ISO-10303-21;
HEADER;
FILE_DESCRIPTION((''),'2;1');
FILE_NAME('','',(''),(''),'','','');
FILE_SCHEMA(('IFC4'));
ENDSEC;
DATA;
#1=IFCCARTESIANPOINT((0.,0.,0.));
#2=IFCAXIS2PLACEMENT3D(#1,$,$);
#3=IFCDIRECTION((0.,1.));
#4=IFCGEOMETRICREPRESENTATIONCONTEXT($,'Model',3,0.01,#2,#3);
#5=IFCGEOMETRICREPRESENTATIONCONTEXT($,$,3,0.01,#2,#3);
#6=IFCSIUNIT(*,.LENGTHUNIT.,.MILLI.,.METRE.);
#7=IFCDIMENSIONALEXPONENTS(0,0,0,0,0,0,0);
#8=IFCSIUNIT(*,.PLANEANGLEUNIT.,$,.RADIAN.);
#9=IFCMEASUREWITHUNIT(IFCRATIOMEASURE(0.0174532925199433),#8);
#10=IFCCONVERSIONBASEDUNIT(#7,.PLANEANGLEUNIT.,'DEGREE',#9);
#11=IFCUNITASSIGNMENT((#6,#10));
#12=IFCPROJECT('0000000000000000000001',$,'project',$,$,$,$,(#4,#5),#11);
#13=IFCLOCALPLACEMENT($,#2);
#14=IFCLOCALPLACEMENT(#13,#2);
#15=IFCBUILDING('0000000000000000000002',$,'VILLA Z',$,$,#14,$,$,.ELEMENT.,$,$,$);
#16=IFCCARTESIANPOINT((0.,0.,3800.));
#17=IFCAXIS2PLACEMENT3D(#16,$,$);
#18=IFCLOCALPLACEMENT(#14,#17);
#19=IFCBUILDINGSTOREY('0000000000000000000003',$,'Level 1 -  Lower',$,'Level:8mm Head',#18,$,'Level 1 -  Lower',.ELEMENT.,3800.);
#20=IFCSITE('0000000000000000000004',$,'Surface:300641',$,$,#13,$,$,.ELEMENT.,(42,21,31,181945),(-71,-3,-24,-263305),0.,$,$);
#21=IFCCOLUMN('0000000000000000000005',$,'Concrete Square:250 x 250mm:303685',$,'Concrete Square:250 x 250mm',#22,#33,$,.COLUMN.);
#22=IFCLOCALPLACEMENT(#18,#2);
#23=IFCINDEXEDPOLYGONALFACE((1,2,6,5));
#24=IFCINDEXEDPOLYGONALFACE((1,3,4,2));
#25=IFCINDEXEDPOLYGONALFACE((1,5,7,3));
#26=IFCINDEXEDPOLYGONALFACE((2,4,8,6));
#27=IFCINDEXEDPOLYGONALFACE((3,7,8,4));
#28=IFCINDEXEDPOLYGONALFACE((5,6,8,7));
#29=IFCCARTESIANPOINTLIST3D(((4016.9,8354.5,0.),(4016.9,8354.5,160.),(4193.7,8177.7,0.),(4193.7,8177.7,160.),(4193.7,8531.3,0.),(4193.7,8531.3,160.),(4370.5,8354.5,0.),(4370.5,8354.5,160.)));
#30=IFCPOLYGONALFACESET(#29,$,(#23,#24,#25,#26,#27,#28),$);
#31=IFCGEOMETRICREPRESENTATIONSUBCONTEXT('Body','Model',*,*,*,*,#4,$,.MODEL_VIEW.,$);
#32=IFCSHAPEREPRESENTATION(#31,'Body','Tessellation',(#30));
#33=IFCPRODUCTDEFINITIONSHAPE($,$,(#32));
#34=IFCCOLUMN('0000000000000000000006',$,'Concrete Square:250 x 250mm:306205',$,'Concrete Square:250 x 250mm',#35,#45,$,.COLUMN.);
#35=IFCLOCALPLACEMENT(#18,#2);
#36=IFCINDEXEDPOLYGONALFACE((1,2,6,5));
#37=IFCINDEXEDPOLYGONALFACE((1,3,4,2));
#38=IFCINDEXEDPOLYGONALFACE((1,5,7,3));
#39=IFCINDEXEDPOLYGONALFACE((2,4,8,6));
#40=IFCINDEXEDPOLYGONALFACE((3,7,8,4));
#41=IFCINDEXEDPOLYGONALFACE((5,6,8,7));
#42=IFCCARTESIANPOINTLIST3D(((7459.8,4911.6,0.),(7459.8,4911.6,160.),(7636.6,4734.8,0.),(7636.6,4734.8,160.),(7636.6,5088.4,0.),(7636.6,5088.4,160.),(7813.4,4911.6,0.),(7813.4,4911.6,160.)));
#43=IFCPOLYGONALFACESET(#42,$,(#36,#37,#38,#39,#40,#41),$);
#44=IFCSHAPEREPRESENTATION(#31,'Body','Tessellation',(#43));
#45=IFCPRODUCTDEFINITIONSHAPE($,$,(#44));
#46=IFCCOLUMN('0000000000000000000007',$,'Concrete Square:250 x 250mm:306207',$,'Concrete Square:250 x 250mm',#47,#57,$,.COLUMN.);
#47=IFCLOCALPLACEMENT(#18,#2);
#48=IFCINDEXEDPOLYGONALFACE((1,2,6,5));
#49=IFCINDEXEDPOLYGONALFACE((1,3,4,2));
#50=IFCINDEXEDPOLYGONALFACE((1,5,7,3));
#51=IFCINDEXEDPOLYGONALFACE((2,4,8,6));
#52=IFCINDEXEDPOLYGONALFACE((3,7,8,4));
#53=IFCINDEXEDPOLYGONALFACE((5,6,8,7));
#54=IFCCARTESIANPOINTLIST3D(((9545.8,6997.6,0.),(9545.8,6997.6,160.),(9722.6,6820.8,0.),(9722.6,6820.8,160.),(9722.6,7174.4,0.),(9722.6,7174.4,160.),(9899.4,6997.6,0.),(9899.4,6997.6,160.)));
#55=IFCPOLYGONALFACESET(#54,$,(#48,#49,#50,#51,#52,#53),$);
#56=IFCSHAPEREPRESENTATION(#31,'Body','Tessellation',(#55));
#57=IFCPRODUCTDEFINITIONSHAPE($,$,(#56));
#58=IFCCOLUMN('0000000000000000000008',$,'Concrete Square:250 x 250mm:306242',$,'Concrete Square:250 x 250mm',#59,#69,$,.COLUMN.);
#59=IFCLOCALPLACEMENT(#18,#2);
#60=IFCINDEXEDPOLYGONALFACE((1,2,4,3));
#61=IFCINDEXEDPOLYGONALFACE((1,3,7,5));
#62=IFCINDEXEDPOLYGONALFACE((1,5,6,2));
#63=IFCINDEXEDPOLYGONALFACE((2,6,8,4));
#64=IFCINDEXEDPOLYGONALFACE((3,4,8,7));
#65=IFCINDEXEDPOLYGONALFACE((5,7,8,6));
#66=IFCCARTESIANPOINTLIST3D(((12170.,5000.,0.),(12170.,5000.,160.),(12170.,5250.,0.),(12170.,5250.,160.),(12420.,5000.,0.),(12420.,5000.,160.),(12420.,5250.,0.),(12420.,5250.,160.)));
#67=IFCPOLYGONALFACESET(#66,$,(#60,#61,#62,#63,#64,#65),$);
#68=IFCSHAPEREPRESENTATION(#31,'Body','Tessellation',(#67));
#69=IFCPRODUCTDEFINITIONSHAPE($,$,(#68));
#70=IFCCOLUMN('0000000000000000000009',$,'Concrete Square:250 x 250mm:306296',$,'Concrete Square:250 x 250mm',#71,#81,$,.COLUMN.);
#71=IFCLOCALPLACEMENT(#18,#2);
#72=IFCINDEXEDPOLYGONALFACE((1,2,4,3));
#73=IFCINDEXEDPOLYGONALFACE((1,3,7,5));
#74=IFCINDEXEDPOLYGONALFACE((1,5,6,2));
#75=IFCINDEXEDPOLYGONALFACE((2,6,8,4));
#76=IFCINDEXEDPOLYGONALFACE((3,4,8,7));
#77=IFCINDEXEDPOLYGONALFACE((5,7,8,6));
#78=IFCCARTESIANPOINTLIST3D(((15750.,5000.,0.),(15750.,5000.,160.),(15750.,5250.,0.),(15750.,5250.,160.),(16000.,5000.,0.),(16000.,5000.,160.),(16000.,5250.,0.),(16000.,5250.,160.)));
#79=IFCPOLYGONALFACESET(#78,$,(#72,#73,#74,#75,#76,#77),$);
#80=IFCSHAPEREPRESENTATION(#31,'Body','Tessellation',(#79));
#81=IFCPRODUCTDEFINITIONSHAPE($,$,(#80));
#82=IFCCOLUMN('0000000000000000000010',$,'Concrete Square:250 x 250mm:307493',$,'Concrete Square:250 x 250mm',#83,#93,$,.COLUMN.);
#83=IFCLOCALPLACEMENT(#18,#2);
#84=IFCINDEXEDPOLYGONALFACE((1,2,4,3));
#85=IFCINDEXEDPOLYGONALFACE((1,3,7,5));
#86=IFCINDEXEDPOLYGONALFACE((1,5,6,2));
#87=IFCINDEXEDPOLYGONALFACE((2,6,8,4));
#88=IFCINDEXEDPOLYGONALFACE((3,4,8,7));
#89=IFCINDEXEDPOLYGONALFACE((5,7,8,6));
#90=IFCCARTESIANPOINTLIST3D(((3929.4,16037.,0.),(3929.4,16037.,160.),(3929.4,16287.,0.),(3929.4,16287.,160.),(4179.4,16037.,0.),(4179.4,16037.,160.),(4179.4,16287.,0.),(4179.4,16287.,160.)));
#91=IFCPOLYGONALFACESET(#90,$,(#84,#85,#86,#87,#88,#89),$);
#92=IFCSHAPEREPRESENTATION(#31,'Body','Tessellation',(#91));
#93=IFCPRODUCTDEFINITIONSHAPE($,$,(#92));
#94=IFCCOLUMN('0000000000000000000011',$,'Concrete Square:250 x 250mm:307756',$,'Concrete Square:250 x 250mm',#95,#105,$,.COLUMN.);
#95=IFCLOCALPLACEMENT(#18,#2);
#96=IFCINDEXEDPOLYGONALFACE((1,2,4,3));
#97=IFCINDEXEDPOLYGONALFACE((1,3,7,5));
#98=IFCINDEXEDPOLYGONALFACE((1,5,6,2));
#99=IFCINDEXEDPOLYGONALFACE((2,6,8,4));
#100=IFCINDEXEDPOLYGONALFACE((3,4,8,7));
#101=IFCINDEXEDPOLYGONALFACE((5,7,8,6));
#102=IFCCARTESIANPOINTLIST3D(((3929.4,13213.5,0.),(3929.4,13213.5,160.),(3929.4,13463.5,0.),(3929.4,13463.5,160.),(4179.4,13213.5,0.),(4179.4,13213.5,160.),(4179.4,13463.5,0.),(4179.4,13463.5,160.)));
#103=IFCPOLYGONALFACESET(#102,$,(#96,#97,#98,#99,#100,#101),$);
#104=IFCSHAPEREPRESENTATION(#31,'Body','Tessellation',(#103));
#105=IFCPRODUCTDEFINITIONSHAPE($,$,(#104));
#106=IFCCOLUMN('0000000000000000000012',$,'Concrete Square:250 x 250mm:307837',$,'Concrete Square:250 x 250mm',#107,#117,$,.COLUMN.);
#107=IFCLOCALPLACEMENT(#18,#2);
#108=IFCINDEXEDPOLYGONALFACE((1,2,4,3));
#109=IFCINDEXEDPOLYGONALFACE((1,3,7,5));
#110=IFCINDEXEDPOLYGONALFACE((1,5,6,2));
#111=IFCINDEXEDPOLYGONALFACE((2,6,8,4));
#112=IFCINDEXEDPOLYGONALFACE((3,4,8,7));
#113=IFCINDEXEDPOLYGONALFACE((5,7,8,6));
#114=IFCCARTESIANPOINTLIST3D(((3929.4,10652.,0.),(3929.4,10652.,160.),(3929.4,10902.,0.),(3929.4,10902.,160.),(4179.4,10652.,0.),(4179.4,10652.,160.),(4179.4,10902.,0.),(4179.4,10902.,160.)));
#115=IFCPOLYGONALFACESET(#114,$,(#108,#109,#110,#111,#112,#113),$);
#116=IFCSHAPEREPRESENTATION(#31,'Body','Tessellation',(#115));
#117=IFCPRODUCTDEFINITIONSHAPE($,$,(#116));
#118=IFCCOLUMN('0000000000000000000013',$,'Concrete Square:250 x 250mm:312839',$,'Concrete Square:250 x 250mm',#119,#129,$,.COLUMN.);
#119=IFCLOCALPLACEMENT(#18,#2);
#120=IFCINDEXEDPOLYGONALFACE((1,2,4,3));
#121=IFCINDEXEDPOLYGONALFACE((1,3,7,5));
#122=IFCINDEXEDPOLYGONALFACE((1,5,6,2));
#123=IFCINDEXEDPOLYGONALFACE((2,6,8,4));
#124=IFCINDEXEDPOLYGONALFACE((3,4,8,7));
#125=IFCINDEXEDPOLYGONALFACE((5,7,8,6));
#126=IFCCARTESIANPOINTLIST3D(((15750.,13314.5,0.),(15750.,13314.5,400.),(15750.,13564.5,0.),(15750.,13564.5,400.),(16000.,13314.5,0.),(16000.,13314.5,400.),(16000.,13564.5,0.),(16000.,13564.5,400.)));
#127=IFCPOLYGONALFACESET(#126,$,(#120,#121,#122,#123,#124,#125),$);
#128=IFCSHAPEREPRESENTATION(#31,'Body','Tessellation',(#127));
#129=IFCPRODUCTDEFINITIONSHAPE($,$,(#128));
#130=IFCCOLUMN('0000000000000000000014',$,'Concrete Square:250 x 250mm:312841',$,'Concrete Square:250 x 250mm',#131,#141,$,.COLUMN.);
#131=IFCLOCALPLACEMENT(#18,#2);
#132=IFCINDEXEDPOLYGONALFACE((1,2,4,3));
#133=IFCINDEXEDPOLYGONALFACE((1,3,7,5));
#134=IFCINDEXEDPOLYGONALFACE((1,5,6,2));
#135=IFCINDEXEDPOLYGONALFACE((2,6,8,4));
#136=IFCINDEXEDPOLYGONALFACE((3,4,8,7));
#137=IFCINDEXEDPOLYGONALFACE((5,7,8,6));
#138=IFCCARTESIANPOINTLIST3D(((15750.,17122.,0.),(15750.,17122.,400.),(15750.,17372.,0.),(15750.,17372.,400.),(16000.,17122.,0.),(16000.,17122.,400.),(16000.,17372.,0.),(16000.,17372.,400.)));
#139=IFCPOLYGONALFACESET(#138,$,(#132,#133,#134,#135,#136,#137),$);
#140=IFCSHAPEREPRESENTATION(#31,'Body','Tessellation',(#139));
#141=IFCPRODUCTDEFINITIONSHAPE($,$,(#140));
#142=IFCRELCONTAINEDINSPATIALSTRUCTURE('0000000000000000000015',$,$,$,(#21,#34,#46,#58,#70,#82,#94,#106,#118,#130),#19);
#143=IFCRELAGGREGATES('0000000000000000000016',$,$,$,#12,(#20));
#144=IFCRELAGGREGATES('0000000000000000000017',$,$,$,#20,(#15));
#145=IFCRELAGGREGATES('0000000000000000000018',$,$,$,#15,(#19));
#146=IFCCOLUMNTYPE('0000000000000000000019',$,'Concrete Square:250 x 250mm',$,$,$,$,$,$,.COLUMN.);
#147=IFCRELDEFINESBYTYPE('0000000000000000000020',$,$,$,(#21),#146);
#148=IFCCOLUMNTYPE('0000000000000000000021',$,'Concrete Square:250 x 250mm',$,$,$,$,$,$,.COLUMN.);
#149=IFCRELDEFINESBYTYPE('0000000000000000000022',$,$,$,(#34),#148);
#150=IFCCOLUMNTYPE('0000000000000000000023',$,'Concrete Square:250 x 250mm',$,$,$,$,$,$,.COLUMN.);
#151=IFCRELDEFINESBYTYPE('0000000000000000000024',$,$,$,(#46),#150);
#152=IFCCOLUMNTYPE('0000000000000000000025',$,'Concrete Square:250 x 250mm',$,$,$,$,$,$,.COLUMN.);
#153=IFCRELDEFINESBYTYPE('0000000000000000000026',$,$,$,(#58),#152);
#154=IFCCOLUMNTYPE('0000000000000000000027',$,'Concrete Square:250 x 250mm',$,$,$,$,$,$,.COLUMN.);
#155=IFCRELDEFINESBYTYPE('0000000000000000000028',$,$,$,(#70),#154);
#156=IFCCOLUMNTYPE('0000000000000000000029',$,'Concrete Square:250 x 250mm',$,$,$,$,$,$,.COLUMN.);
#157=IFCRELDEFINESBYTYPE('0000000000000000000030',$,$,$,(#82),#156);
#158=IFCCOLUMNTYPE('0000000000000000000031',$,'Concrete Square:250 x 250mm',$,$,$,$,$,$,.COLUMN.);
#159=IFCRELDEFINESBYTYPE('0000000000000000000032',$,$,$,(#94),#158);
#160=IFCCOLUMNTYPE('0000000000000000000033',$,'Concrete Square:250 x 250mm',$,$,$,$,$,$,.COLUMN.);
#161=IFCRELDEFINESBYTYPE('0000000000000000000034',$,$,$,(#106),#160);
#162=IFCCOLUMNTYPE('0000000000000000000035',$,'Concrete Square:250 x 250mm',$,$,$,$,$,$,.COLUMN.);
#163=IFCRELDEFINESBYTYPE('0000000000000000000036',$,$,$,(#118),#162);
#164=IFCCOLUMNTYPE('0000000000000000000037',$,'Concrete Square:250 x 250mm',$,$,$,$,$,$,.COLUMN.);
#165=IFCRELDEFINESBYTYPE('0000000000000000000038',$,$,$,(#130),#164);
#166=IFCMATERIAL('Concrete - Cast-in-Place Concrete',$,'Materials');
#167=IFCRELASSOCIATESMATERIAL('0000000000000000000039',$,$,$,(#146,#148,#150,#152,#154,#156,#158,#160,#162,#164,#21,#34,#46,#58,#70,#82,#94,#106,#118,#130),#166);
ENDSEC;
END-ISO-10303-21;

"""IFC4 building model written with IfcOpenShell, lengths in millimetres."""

from ifc_helpers import new_model, entity, si_unit, converted_unit, direction, frame, frame_2d, origin, origin_2d_with_axis, place, context, subcontext, project, spatial, rectangle, extrude, source, transform, mapped, material, material_profile, profile_set, profile_usage, type_object, type_shapes, element, save


model = new_model("IFC4")

# Units and contexts
model_context = context("Model", 3, precision=0.01, world=origin(), true_north=direction((0.0, 1.0)))
context_of_model = context(None, 3, precision=0.01, world=origin(), true_north=direction((0.0, 1.0)))
body_context = subcontext(model_context, "Body", "Model", "MODEL_VIEW")
ifc_project = project(units=[si_unit("LENGTHUNIT", "METRE", prefix="MILLI"), converted_unit("PLANEANGLEUNIT", "DEGREE", entity("IfcRatioMeasure", 0.0174532925199433), si_unit("PLANEANGLEUNIT", "RADIAN"), dimensions=[0, 0, 0, 0, 0, 0, 0])], contexts=[model_context, context_of_model])

# Site, building, storey
site_placement = place(None, origin())
site = spatial("IfcSite", under=ifc_project, at=site_placement, Name="Surface:300641", CompositionType="ELEMENT", RefLatitude=(42, 21, 31, 181945), RefLongitude=(-71, -3, -24, -263305), RefElevation=0.0)
building_placement = place(site_placement, origin())
building = spatial("IfcBuilding", under=site, at=building_placement, Name="VILLA Z", CompositionType="ELEMENT")
storey_placement = place(building_placement, frame((0.0, 0.0, 3800.0)))
storey = spatial("IfcBuildingStorey", under=building, at=storey_placement, Name="Level 1 -  Lower", ObjectType="Level:8mm Head", LongName="Level 1 -  Lower", CompositionType="ELEMENT", Elevation=3800.0)

# Columns
ifc_material_1 = material(Name="Concrete - Cast-in-Place Concrete", Category="Materials")
ifc_material_profile_1 = material_profile(ifc_material_1, rectangle(XDim=250.0, YDim=250.0, at=frame_2d((0.0, 0.0), x_axis=(1.0, 0.0))), Name="250 x 250mm")
ifc_profile_set_1 = profile_set([ifc_material_profile_1], Name="250 x 250mm")
ifc_profile_usage_1 = profile_usage(ifc_profile_set_1)
column_type_1 = type_object("IfcColumnType", Name="Concrete Square:250 x 250mm", PredefinedType="COLUMN", material=ifc_profile_set_1)
shared_shape_1 = source(origin(), body_context, "Body", "SweptSolid", [
    extrude(rectangle(XDim=250.0, YDim=250.0, at=frame_2d((0.0, 0.0), x_axis=(1.0, 0.0))), frame((4193.7, 8354.5, 3800.0), z_axis=(0.0, 0.0, 1.0), x_axis=(-0.707107, 0.707107, 0.0)), (0.0, 0.0, 1.0), 160.0),
])
type_shapes(column_type_1, [shared_shape_1])
column_1_placement = place(storey_placement, frame((0.0, 0.0, -3800.0)))
element("IfcColumn", 1, at=column_1_placement, inside=storey, type_object=column_type_1, material=ifc_profile_usage_1, Name="Concrete Square:250 x 250mm:303685", ObjectType="Concrete Square:250 x 250mm", PredefinedType="COLUMN", context=body_context, shape_type="MappedRepresentation", body=[
    mapped(shared_shape_1, transform((0.0, 0.0, 0.0), scale=1.0)),
])
ifc_profile_usage_2 = profile_usage(ifc_profile_set_1)
column_type_2 = type_object("IfcColumnType", Name="Concrete Square:250 x 250mm", PredefinedType="COLUMN", material=ifc_profile_set_1)
shared_shape_2 = source(origin(), body_context, "Body", "SweptSolid", [
    extrude(rectangle(XDim=250.0, YDim=250.0, at=frame_2d((0.0, 0.0), x_axis=(1.0, 0.0))), frame((7636.6, 4911.6, 3800.0), z_axis=(0.0, 0.0, 1.0), x_axis=(-0.707107, 0.707107, 0.0)), (0.0, 0.0, 1.0), 160.0),
])
type_shapes(column_type_2, [shared_shape_2])
column_2_placement = place(storey_placement, frame((0.0, 0.0, -3800.0)))
element("IfcColumn", 2, at=column_2_placement, inside=storey, type_object=column_type_2, material=ifc_profile_usage_2, Name="Concrete Square:250 x 250mm:306205", ObjectType="Concrete Square:250 x 250mm", PredefinedType="COLUMN", context=body_context, shape_type="MappedRepresentation", body=[
    mapped(shared_shape_2, transform((0.0, 0.0, 0.0), scale=1.0)),
])
ifc_profile_usage_3 = profile_usage(ifc_profile_set_1)
column_type_3 = type_object("IfcColumnType", Name="Concrete Square:250 x 250mm", PredefinedType="COLUMN", material=ifc_profile_set_1)
shared_shape_3 = source(origin(), body_context, "Body", "SweptSolid", [
    extrude(rectangle(XDim=250.0, YDim=250.0, at=frame_2d((0.0, 0.0), x_axis=(1.0, 0.0))), frame((9722.6, 6997.6, 3800.0), z_axis=(0.0, 0.0, 1.0), x_axis=(-0.707107, 0.707107, 0.0)), (0.0, 0.0, 1.0), 160.0),
])
type_shapes(column_type_3, [shared_shape_3])
column_3_placement = place(storey_placement, frame((0.0, 0.0, -3800.0)))
element("IfcColumn", 3, at=column_3_placement, inside=storey, type_object=column_type_3, material=ifc_profile_usage_3, Name="Concrete Square:250 x 250mm:306207", ObjectType="Concrete Square:250 x 250mm", PredefinedType="COLUMN", context=body_context, shape_type="MappedRepresentation", body=[
    mapped(shared_shape_3, transform((0.0, 0.0, 0.0), scale=1.0)),
])
ifc_profile_usage_4 = profile_usage(ifc_profile_set_1)
column_type_4 = type_object("IfcColumnType", Name="Concrete Square:250 x 250mm", PredefinedType="COLUMN", material=ifc_profile_set_1)
shared_shape_4 = source(origin(), body_context, "Body", "SweptSolid", [
    extrude(rectangle(XDim=250.0, YDim=250.0, at=origin_2d_with_axis()), frame((12295.0, 5125.0, 3800.0), z_axis=(0.0, 0.0, 1.0), x_axis=(0.0, -1.0, 0.0)), (0.0, 0.0, 1.0), 160.0),
])
type_shapes(column_type_4, [shared_shape_4])
column_4_placement = place(storey_placement, frame((0.0, 0.0, -3800.0)))
element("IfcColumn", 4, at=column_4_placement, inside=storey, type_object=column_type_4, material=ifc_profile_usage_4, Name="Concrete Square:250 x 250mm:306242", ObjectType="Concrete Square:250 x 250mm", PredefinedType="COLUMN", context=body_context, shape_type="MappedRepresentation", body=[
    mapped(shared_shape_4, transform((0.0, 0.0, 0.0), scale=1.0)),
])
ifc_profile_usage_5 = profile_usage(ifc_profile_set_1)
column_type_5 = type_object("IfcColumnType", Name="Concrete Square:250 x 250mm", PredefinedType="COLUMN", material=ifc_profile_set_1)
shared_shape_5 = source(origin(), body_context, "Body", "SweptSolid", [
    extrude(rectangle(XDim=250.0, YDim=250.0, at=origin_2d_with_axis()), frame((15875.0, 5125.0, 3800.0), z_axis=(0.0, 0.0, 1.0), x_axis=(0.0, -1.0, 0.0)), (0.0, 0.0, 1.0), 160.0),
])
type_shapes(column_type_5, [shared_shape_5])
column_5_placement = place(storey_placement, frame((0.0, 0.0, -3800.0)))
element("IfcColumn", 5, at=column_5_placement, inside=storey, type_object=column_type_5, material=ifc_profile_usage_5, Name="Concrete Square:250 x 250mm:306296", ObjectType="Concrete Square:250 x 250mm", PredefinedType="COLUMN", context=body_context, shape_type="MappedRepresentation", body=[
    mapped(shared_shape_5, transform((0.0, 0.0, 0.0), scale=1.0)),
])
ifc_profile_usage_6 = profile_usage(ifc_profile_set_1)
column_type_6 = type_object("IfcColumnType", Name="Concrete Square:250 x 250mm", PredefinedType="COLUMN", material=ifc_profile_set_1)
shared_shape_6 = source(origin(), body_context, "Body", "SweptSolid", [
    extrude(rectangle(XDim=250.0, YDim=250.0, at=frame_2d((0.0, 0.0), x_axis=(1.0, 0.0))), frame((4054.4, 16162.0, 3800.0), z_axis=(0.0, 0.0, 1.0), x_axis=(0.0, -1.0, 0.0)), (0.0, 0.0, 1.0), 160.0),
])
type_shapes(column_type_6, [shared_shape_6])
column_6_placement = place(storey_placement, frame((0.0, 0.0, -3800.0)))
element("IfcColumn", 6, at=column_6_placement, inside=storey, type_object=column_type_6, material=ifc_profile_usage_6, Name="Concrete Square:250 x 250mm:307493", ObjectType="Concrete Square:250 x 250mm", PredefinedType="COLUMN", context=body_context, shape_type="MappedRepresentation", body=[
    mapped(shared_shape_6, transform((0.0, 0.0, 0.0), scale=1.0)),
])
ifc_profile_usage_7 = profile_usage(ifc_profile_set_1)
column_type_7 = type_object("IfcColumnType", Name="Concrete Square:250 x 250mm", PredefinedType="COLUMN", material=ifc_profile_set_1)
shared_shape_7 = source(origin(), body_context, "Body", "SweptSolid", [
    extrude(rectangle(XDim=250.0, YDim=250.0, at=frame_2d((0.0, 0.0), x_axis=(1.0, 0.0))), frame((4054.4, 13338.5, 3800.0), z_axis=(0.0, 0.0, 1.0), x_axis=(0.0, -1.0, 0.0)), (0.0, 0.0, 1.0), 160.0),
])
type_shapes(column_type_7, [shared_shape_7])
column_7_placement = place(storey_placement, frame((0.0, 0.0, -3800.0)))
element("IfcColumn", 7, at=column_7_placement, inside=storey, type_object=column_type_7, material=ifc_profile_usage_7, Name="Concrete Square:250 x 250mm:307756", ObjectType="Concrete Square:250 x 250mm", PredefinedType="COLUMN", context=body_context, shape_type="MappedRepresentation", body=[
    mapped(shared_shape_7, transform((0.0, 0.0, 0.0), scale=1.0)),
])
ifc_profile_usage_8 = profile_usage(ifc_profile_set_1)
column_type_8 = type_object("IfcColumnType", Name="Concrete Square:250 x 250mm", PredefinedType="COLUMN", material=ifc_profile_set_1)
shared_shape_8 = source(origin(), body_context, "Body", "SweptSolid", [
    extrude(rectangle(XDim=250.0, YDim=250.0, at=frame_2d((0.0, 0.0), x_axis=(1.0, 0.0))), frame((4054.4, 10777.0, 3800.0), z_axis=(0.0, 0.0, 1.0), x_axis=(0.0, -1.0, 0.0)), (0.0, 0.0, 1.0), 160.0),
])
type_shapes(column_type_8, [shared_shape_8])
column_8_placement = place(storey_placement, frame((0.0, 0.0, -3800.0)))
element("IfcColumn", 8, at=column_8_placement, inside=storey, type_object=column_type_8, material=ifc_profile_usage_8, Name="Concrete Square:250 x 250mm:307837", ObjectType="Concrete Square:250 x 250mm", PredefinedType="COLUMN", context=body_context, shape_type="MappedRepresentation", body=[
    mapped(shared_shape_8, transform((0.0, 0.0, 0.0), scale=1.0)),
])
ifc_profile_usage_9 = profile_usage(ifc_profile_set_1)
column_type_9 = type_object("IfcColumnType", Name="Concrete Square:250 x 250mm", PredefinedType="COLUMN", material=ifc_profile_set_1)
shared_shape_9 = source(origin(), body_context, "Body", "SweptSolid", [
    extrude(rectangle(XDim=250.0, YDim=250.0, at=frame_2d((0.0, 0.0), x_axis=(1.0, 0.0))), frame((15875.0, 13439.5, 3800.0), z_axis=(0.0, 0.0, 1.0), x_axis=(0.0, -1.0, 0.0)), (0.0, 0.0, 1.0), 400.0),
])
type_shapes(column_type_9, [shared_shape_9])
column_9_placement = place(storey_placement, frame((0.0, 0.0, -3800.0)))
element("IfcColumn", 9, at=column_9_placement, inside=storey, type_object=column_type_9, material=ifc_profile_usage_9, Name="Concrete Square:250 x 250mm:312839", ObjectType="Concrete Square:250 x 250mm", PredefinedType="COLUMN", context=body_context, shape_type="MappedRepresentation", body=[
    mapped(shared_shape_9, transform((0.0, 0.0, 0.0), scale=1.0)),
])
ifc_profile_usage_10 = profile_usage(ifc_profile_set_1)
column_type_10 = type_object("IfcColumnType", Name="Concrete Square:250 x 250mm", PredefinedType="COLUMN", material=ifc_profile_set_1)
shared_shape_10 = source(origin(), body_context, "Body", "SweptSolid", [
    extrude(rectangle(XDim=250.0, YDim=250.0, at=origin_2d_with_axis()), frame((15875.0, 17247.0, 3800.0), z_axis=(0.0, 0.0, 1.0), x_axis=(0.0, -1.0, 0.0)), (0.0, 0.0, 1.0), 400.0),
])
type_shapes(column_type_10, [shared_shape_10])
column_10_placement = place(storey_placement, frame((0.0, 0.0, -3800.0)))
element("IfcColumn", 10, at=column_10_placement, inside=storey, type_object=column_type_10, material=ifc_profile_usage_10, Name="Concrete Square:250 x 250mm:312841", ObjectType="Concrete Square:250 x 250mm", PredefinedType="COLUMN", context=body_context, shape_type="MappedRepresentation", body=[
    mapped(shared_shape_10, transform((0.0, 0.0, 0.0), scale=1.0)),
])

save(model, "model.ifc")
